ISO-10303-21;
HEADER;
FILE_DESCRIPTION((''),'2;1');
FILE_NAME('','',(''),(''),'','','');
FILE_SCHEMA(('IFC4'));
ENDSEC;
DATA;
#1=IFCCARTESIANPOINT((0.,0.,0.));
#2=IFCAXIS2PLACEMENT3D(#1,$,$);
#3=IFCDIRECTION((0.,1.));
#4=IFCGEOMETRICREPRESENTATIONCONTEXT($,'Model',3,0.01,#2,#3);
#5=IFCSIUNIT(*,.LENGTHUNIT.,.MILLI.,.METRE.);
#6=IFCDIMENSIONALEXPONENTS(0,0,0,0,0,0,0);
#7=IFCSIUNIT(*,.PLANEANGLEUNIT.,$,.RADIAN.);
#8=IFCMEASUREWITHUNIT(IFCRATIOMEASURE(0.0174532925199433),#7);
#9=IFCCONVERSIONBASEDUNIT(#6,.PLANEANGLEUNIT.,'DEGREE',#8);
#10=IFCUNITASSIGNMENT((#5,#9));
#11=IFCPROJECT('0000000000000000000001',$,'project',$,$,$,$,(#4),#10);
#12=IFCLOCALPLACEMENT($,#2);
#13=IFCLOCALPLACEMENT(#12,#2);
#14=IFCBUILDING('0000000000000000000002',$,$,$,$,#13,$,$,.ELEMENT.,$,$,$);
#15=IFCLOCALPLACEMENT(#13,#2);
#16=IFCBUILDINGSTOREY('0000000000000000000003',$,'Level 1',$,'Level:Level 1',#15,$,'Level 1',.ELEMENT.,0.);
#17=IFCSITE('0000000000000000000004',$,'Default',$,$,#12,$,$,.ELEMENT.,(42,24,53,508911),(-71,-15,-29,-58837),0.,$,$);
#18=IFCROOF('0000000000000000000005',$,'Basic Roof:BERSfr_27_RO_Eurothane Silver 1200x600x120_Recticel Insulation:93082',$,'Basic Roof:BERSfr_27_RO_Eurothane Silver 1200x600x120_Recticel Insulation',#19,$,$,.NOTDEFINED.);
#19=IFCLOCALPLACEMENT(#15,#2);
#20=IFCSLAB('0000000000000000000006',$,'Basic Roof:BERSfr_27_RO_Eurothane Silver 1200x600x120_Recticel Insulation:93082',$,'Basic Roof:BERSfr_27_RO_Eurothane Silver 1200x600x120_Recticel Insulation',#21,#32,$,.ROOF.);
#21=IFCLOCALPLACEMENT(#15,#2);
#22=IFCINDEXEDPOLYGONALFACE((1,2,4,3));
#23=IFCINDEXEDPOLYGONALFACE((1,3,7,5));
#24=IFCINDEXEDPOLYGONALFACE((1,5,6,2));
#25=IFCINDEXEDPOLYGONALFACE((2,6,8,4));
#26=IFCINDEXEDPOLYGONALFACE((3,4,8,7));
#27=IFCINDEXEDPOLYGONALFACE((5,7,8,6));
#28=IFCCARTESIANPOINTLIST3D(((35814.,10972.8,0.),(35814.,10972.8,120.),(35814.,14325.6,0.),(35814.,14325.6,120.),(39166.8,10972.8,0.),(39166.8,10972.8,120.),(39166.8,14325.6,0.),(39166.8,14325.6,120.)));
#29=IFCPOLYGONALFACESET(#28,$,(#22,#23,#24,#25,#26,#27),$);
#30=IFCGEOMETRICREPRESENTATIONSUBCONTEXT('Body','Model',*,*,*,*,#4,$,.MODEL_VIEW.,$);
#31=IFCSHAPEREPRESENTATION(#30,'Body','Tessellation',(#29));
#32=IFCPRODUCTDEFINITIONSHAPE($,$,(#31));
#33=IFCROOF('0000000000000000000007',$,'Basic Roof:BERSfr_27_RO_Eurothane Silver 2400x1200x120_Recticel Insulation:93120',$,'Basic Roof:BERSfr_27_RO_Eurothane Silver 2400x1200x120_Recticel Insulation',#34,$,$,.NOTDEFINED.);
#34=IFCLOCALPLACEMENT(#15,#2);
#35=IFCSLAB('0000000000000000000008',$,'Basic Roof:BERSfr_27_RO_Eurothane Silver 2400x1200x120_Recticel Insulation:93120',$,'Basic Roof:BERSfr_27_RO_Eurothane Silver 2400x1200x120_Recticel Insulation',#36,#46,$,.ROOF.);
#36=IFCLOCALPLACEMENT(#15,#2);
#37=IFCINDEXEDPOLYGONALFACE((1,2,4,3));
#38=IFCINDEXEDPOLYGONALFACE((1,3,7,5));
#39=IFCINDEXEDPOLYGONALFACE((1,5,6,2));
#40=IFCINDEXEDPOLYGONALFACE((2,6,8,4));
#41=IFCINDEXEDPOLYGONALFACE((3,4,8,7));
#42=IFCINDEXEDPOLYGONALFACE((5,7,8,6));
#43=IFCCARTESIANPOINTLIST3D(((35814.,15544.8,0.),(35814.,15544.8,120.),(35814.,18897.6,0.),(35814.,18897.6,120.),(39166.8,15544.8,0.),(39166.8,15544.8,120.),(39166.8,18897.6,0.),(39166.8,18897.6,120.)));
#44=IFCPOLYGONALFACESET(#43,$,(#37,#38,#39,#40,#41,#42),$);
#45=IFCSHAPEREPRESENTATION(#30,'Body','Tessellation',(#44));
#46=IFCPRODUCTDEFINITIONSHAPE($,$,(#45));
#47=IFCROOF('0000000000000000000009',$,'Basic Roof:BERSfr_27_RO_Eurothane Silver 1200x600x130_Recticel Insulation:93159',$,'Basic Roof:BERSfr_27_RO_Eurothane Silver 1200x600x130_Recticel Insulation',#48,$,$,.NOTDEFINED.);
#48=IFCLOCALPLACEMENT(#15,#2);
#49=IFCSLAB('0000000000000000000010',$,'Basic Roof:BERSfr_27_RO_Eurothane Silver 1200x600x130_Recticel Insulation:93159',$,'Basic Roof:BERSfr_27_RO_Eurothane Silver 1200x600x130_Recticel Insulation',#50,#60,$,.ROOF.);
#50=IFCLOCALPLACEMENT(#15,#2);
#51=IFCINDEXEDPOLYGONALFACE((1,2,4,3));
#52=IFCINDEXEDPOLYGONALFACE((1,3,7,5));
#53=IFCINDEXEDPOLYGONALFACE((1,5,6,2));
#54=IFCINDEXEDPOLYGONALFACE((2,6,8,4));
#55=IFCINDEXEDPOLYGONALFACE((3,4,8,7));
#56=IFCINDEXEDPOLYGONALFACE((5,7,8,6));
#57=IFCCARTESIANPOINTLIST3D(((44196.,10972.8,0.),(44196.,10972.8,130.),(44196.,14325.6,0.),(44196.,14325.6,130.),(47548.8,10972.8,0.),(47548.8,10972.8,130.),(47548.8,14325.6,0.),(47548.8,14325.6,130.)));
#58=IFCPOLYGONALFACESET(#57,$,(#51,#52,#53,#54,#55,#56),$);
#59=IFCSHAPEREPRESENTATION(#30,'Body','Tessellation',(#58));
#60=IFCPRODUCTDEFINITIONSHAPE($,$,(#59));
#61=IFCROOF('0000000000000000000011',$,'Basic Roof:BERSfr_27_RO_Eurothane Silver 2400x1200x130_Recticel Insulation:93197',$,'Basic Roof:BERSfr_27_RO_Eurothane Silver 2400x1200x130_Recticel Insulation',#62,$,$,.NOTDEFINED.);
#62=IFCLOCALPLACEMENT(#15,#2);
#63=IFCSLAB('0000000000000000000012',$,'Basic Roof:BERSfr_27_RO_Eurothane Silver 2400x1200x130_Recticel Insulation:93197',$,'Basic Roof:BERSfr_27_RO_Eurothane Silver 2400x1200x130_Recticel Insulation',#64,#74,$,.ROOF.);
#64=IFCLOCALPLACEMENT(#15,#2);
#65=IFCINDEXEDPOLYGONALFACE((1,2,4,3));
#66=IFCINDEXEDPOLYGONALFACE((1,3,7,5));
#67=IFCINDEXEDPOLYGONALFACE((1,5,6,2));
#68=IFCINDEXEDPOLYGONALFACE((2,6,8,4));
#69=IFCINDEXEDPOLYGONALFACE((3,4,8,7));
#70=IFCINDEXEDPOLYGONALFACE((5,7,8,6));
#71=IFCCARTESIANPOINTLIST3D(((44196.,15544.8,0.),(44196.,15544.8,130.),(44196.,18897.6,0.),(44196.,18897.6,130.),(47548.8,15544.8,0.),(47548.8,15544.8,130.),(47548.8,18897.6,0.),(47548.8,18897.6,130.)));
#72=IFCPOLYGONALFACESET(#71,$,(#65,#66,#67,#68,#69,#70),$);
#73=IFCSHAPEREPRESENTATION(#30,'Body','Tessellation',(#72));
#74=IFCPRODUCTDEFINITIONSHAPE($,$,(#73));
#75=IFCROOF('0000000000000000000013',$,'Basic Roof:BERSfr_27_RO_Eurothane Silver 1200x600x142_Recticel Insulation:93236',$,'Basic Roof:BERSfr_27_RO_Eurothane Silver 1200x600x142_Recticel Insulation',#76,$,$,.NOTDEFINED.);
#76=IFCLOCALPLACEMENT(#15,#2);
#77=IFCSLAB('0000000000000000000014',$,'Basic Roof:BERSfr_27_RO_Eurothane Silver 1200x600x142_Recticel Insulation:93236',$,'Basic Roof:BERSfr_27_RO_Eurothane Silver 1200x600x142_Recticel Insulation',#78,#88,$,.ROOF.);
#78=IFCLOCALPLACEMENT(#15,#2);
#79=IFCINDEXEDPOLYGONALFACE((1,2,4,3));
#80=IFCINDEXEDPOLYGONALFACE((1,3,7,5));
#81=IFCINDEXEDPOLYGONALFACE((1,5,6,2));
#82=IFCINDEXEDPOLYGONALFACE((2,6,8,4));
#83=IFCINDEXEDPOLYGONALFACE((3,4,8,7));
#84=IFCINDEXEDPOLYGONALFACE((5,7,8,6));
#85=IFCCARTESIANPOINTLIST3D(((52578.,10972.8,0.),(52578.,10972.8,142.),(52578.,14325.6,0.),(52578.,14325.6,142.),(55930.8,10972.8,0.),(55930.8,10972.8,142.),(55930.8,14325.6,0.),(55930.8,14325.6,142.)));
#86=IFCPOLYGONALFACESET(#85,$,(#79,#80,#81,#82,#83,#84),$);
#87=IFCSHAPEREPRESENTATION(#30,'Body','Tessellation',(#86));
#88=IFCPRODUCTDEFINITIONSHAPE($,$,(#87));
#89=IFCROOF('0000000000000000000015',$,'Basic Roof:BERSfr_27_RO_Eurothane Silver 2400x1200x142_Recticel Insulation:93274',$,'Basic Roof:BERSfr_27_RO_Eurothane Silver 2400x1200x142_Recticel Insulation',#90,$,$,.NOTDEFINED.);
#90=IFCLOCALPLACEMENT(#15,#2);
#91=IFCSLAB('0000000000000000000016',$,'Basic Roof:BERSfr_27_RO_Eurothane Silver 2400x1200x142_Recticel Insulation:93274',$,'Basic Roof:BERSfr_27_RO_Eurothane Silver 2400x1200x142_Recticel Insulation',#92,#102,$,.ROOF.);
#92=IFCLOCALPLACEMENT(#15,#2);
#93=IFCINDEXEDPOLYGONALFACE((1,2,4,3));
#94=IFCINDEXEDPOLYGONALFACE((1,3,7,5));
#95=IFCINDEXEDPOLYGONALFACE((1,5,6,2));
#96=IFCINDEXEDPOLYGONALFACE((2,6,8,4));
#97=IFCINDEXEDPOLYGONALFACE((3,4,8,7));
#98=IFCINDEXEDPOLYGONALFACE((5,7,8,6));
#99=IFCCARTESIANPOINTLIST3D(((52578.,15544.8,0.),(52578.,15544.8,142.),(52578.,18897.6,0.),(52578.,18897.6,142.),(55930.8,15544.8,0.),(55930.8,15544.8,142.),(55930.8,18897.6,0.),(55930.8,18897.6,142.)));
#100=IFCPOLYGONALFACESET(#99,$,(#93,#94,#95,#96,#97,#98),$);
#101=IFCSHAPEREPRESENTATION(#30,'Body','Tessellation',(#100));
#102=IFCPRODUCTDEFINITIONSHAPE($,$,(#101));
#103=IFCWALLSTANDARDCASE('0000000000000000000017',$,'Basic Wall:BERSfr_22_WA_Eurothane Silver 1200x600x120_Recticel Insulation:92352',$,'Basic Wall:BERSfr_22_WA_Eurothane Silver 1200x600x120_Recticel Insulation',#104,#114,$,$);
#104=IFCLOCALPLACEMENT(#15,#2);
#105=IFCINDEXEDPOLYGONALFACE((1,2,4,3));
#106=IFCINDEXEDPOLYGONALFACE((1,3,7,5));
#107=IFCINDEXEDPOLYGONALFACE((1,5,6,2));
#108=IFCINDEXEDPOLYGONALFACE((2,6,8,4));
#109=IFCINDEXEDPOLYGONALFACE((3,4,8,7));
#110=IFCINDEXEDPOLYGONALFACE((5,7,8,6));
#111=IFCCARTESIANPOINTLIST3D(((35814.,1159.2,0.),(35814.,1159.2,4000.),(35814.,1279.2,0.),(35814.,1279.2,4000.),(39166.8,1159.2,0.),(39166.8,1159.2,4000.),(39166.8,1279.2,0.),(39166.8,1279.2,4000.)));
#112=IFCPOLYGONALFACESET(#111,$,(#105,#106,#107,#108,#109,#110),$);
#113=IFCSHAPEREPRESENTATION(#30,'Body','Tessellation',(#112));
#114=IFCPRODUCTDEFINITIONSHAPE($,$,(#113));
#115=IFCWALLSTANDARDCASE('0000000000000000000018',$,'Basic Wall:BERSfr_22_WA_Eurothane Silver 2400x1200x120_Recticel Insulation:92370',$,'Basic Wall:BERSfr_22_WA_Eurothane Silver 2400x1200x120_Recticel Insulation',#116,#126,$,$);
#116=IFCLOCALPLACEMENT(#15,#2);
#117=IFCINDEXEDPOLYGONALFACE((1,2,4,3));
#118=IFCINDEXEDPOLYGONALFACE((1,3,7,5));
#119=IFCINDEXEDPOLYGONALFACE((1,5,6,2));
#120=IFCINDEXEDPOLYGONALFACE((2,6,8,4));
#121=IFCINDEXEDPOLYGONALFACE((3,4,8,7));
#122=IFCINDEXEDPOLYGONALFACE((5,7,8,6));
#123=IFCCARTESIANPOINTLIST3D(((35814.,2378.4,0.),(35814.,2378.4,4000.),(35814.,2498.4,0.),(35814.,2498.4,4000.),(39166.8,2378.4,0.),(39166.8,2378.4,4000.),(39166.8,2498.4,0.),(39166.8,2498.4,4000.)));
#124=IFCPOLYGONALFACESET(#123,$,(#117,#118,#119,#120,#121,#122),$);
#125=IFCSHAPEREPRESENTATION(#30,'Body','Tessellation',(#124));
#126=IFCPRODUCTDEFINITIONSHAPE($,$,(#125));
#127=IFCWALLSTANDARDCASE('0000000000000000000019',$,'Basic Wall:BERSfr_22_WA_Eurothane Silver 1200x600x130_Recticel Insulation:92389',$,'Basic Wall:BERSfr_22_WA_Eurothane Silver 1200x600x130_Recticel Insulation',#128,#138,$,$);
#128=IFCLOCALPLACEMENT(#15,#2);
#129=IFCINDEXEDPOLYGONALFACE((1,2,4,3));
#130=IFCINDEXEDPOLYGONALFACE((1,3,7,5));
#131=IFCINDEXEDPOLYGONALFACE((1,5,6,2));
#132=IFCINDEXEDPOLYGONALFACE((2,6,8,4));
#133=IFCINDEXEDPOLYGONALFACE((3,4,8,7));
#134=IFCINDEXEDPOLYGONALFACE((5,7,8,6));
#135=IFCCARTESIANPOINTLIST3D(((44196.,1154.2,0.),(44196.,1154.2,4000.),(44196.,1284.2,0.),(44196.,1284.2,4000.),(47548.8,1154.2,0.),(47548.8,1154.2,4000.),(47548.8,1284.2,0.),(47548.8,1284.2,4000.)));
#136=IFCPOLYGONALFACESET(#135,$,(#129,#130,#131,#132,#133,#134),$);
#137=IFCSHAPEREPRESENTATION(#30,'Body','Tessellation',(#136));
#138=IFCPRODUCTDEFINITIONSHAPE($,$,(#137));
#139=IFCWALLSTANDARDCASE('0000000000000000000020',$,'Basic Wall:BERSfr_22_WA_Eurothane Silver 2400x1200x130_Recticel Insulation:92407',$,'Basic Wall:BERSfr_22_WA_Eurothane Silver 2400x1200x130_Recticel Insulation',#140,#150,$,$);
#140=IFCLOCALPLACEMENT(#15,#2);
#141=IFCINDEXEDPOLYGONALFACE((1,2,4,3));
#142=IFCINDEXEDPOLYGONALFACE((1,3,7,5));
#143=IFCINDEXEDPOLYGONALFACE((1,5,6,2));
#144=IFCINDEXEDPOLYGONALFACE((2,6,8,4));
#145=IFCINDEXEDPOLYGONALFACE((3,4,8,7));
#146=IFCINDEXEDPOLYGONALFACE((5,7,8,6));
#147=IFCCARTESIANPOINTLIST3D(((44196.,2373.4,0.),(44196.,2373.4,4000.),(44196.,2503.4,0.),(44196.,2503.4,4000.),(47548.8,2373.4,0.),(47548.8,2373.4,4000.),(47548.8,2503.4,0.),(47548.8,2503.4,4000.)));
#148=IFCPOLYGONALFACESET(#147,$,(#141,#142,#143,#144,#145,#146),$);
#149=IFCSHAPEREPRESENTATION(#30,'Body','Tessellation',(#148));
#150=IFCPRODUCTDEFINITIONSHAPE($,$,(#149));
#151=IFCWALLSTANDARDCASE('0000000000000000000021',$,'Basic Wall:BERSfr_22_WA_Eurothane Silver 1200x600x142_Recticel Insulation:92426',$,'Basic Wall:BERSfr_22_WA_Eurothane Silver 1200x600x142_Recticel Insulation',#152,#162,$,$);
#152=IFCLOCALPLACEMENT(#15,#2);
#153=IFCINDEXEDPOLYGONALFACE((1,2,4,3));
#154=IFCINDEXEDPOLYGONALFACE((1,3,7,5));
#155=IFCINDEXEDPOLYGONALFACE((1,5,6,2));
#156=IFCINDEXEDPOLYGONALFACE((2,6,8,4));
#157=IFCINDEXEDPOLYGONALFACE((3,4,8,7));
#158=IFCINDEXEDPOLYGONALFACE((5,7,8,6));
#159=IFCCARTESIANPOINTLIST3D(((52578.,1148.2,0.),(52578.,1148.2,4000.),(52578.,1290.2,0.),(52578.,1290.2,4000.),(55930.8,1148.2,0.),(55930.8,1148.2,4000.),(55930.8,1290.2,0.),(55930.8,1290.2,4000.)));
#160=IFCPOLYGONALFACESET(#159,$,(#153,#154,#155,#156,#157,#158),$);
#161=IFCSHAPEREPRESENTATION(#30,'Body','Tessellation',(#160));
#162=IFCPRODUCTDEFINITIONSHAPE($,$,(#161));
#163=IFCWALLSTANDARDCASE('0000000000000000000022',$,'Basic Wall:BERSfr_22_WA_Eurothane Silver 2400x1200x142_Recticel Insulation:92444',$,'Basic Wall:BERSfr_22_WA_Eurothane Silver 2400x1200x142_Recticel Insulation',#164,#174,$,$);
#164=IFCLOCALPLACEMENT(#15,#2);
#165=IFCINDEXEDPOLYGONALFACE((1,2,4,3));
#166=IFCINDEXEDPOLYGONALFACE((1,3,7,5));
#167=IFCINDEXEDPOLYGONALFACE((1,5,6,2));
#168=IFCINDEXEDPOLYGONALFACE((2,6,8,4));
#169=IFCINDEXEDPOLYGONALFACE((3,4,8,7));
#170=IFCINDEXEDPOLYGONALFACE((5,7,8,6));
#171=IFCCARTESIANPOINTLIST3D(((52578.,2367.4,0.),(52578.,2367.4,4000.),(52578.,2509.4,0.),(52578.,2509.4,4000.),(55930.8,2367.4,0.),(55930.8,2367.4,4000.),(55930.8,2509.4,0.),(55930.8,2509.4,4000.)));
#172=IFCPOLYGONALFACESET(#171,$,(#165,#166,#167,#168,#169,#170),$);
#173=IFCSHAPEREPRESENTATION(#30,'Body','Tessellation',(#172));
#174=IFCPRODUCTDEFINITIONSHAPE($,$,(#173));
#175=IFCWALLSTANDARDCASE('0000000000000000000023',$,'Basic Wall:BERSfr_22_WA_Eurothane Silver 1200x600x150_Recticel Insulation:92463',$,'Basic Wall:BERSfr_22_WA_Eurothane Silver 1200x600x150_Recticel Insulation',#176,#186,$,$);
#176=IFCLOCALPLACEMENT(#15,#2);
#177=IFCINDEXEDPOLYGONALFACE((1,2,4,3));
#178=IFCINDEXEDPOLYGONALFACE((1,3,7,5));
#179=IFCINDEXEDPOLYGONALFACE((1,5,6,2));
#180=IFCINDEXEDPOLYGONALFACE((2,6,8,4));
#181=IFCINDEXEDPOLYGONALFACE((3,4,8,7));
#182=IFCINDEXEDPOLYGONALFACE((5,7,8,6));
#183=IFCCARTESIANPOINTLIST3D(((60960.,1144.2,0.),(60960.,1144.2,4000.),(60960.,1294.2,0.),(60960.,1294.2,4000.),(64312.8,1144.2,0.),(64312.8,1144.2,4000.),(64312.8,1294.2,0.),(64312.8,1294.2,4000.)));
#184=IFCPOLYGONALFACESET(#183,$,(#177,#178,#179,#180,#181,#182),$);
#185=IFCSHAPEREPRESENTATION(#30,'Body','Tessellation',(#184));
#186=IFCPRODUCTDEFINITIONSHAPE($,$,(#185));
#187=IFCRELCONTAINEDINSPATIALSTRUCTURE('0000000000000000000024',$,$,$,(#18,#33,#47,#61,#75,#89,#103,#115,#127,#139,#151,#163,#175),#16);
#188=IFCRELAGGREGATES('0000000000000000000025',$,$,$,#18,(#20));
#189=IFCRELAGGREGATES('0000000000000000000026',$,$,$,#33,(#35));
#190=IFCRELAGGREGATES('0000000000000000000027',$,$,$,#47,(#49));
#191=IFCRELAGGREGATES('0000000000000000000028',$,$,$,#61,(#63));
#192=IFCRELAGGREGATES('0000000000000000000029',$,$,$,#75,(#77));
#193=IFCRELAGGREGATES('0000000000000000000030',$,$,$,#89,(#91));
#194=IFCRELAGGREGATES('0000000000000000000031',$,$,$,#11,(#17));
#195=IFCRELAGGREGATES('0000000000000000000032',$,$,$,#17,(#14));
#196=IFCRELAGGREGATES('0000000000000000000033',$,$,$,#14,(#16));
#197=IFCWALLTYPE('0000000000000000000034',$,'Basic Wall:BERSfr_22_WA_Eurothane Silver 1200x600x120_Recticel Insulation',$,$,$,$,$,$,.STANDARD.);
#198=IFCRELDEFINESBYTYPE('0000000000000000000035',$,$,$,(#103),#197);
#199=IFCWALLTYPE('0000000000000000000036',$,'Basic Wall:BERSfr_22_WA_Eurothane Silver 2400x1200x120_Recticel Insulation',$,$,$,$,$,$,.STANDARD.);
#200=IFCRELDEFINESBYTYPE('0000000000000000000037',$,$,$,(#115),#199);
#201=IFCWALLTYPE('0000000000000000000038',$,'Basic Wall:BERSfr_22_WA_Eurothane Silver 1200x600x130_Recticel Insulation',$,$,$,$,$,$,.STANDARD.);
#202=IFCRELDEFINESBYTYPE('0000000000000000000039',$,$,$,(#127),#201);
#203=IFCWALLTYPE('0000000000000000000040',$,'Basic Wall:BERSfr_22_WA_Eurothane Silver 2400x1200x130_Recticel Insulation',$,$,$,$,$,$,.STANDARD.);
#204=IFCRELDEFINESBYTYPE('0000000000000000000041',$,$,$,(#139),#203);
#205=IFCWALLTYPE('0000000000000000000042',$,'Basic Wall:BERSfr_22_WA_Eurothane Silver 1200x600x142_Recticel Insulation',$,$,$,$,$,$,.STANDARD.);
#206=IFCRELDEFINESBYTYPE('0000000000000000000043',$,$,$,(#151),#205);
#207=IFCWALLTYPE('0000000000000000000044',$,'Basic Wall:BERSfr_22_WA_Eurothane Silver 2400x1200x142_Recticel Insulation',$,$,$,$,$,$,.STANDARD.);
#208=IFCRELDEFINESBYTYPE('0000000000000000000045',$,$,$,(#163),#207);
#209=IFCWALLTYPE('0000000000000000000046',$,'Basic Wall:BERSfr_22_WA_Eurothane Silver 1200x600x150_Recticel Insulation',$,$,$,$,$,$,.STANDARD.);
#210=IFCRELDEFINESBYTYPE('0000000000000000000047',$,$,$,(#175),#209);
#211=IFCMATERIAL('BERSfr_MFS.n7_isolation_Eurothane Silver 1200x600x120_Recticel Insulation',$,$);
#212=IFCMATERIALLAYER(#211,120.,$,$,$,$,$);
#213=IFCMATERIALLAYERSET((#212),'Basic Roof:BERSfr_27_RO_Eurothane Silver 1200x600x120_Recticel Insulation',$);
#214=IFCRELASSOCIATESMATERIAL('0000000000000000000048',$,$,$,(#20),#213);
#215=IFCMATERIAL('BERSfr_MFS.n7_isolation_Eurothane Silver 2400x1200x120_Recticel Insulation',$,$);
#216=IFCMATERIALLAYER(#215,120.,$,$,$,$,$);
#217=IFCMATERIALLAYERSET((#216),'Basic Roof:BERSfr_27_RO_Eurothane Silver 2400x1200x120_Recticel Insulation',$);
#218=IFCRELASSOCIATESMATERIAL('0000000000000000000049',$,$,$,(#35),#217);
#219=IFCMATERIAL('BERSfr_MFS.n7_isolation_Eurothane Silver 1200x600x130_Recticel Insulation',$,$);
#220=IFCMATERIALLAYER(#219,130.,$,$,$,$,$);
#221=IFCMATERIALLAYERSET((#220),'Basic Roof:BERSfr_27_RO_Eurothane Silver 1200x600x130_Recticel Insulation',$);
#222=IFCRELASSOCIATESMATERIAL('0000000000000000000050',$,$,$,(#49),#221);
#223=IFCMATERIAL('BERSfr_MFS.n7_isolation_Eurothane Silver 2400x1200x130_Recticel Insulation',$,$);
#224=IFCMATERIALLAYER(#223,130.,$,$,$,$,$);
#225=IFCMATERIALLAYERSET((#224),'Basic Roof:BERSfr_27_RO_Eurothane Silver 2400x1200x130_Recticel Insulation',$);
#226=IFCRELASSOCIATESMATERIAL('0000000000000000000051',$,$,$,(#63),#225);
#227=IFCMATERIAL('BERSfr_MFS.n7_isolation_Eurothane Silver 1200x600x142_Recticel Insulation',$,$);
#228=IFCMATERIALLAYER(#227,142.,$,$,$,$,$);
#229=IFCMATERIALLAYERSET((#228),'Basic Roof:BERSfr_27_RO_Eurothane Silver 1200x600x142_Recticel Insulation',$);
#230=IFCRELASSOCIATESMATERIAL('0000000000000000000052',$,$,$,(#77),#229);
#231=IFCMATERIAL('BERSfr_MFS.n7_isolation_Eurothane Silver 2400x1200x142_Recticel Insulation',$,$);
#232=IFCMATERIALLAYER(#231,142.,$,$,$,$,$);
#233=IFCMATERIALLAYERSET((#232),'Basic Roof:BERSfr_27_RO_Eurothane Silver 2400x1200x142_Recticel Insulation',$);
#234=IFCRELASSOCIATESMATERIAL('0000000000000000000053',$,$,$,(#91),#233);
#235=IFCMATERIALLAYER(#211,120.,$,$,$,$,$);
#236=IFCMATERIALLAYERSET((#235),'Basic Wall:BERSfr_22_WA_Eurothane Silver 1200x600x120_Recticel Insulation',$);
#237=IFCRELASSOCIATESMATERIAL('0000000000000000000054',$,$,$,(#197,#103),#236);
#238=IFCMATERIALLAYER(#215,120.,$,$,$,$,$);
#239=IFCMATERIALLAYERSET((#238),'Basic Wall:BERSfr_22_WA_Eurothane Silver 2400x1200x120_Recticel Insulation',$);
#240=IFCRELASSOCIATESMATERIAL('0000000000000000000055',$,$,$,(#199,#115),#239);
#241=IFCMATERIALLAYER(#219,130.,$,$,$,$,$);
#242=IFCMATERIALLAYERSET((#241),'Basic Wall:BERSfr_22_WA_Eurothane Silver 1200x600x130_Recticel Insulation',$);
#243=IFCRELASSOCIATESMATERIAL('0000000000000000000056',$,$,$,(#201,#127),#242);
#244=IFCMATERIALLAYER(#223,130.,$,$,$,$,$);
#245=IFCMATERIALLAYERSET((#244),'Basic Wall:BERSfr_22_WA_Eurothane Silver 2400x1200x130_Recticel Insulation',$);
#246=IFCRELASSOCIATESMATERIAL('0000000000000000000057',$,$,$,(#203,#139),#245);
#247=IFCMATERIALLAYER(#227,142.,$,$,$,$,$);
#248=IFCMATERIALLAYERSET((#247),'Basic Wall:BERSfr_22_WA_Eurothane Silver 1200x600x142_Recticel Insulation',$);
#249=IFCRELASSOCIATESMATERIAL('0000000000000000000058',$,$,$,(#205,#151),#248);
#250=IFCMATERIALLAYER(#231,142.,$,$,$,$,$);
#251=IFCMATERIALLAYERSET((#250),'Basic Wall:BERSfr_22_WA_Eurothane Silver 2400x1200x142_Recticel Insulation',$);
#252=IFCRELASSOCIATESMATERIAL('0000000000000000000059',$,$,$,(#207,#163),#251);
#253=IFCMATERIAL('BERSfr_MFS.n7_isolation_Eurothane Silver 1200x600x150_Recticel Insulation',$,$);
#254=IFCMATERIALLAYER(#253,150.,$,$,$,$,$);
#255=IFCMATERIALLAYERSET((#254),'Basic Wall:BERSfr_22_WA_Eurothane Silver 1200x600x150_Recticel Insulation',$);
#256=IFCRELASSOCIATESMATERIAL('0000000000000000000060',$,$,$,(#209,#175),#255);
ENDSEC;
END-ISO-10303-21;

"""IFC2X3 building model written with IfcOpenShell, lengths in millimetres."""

from ifc_helpers import new_model, entity, si_unit, converted_unit, direction, frame, frame_2d, origin, place, context, subcontext, project, spatial, rectangle, extrude, material, layer, layer_set, layer_usage, type_object, element, aggregate, save


model = new_model("IFC2X3")

# Units and contexts
model_context = context("Model", 3, precision=0.01, world=origin(), true_north=direction((0.0, 1.0)))
body_context = subcontext(model_context, "Body", "Model", "MODEL_VIEW")
ifc_project = project(units=[si_unit("LENGTHUNIT", "METRE", prefix="MILLI"), converted_unit("PLANEANGLEUNIT", "DEGREE", entity("IfcRatioMeasure", 0.0174532925199433), si_unit("PLANEANGLEUNIT", "RADIAN"), dimensions=[0, 0, 0, 0, 0, 0, 0])], contexts=[model_context])

# Site, building, storey
site_placement = place(None, origin())
site = spatial("IfcSite", under=ifc_project, at=site_placement, Name="Default", CompositionType="ELEMENT", RefLatitude=(42, 24, 53, 508911), RefLongitude=(-71, -15, -29, -58837), RefElevation=0.0)
building_placement = place(site_placement, origin())
building = spatial("IfcBuilding", under=site, at=building_placement, CompositionType="ELEMENT")
storey_placement = place(building_placement, origin())
storey = spatial("IfcBuildingStorey", under=building, at=storey_placement, Name="Level 1", ObjectType="Level:Level 1", LongName="Level 1", CompositionType="ELEMENT", Elevation=0.0)

# Roofs, slabs
roof_1_placement = place(storey_placement, frame((35814.0, 10972.8, 0.0)))
roof_1 = element("IfcRoof", 1, at=roof_1_placement, inside=storey, Name="Basic Roof:BERSfr_27_RO_Eurothane Silver 1200x600x120_Recticel Insulation:93082", ObjectType="Basic Roof:BERSfr_27_RO_Eurothane Silver 1200x600x120_Recticel Insulation", ShapeType="NOTDEFINED")
ifc_material_1 = material(Name="BERSfr_MFS.n7_isolation_Eurothane Silver 1200x600x120_Recticel Insulation")
ifc_layer_1 = layer(ifc_material_1, 120.0)
ifc_layer_set_1 = layer_set([ifc_layer_1], Name="Basic Roof:BERSfr_27_RO_Eurothane Silver 1200x600x120_Recticel Insulation")
slab_1_placement = place(roof_1_placement, origin())
slab_1 = element("IfcSlab", 2, at=slab_1_placement, material=ifc_layer_set_1, Name="Basic Roof:BERSfr_27_RO_Eurothane Silver 1200x600x120_Recticel Insulation:93082", ObjectType="Basic Roof:BERSfr_27_RO_Eurothane Silver 1200x600x120_Recticel Insulation", PredefinedType="ROOF", context=body_context, shape_type="SweptSolid", body=[
    extrude(rectangle(XDim=3352.8, YDim=3352.8, at=frame_2d((0.0, 0.0), x_axis=(-1.0, 0.0))), frame((1676.4, 1676.4, 0.0)), (0.0, 0.0, 1.0), 120.0),
])
aggregate(roof_1, [slab_1])
roof_2_placement = place(storey_placement, frame((35814.0, 15544.8, 0.0)))
roof_2 = element("IfcRoof", 3, at=roof_2_placement, inside=storey, Name="Basic Roof:BERSfr_27_RO_Eurothane Silver 2400x1200x120_Recticel Insulation:93120", ObjectType="Basic Roof:BERSfr_27_RO_Eurothane Silver 2400x1200x120_Recticel Insulation", ShapeType="NOTDEFINED")
ifc_material_2 = material(Name="BERSfr_MFS.n7_isolation_Eurothane Silver 2400x1200x120_Recticel Insulation")
ifc_layer_2 = layer(ifc_material_2, 120.0)
ifc_layer_set_2 = layer_set([ifc_layer_2], Name="Basic Roof:BERSfr_27_RO_Eurothane Silver 2400x1200x120_Recticel Insulation")
slab_2_placement = place(roof_2_placement, origin())
slab_2 = element("IfcSlab", 4, at=slab_2_placement, material=ifc_layer_set_2, Name="Basic Roof:BERSfr_27_RO_Eurothane Silver 2400x1200x120_Recticel Insulation:93120", ObjectType="Basic Roof:BERSfr_27_RO_Eurothane Silver 2400x1200x120_Recticel Insulation", PredefinedType="ROOF", context=body_context, shape_type="SweptSolid", body=[
    extrude(rectangle(XDim=3352.8, YDim=3352.8, at=frame_2d((0.0, 0.0), x_axis=(-1.0, 0.0))), frame((1676.4, 1676.4, 0.0)), (0.0, 0.0, 1.0), 120.0),
])
aggregate(roof_2, [slab_2])
roof_3_placement = place(storey_placement, frame((44196.0, 10972.8, 0.0)))
roof_3 = element("IfcRoof", 5, at=roof_3_placement, inside=storey, Name="Basic Roof:BERSfr_27_RO_Eurothane Silver 1200x600x130_Recticel Insulation:93159", ObjectType="Basic Roof:BERSfr_27_RO_Eurothane Silver 1200x600x130_Recticel Insulation", ShapeType="NOTDEFINED")
ifc_material_3 = material(Name="BERSfr_MFS.n7_isolation_Eurothane Silver 1200x600x130_Recticel Insulation")
ifc_layer_3 = layer(ifc_material_3, 130.0)
ifc_layer_set_3 = layer_set([ifc_layer_3], Name="Basic Roof:BERSfr_27_RO_Eurothane Silver 1200x600x130_Recticel Insulation")
slab_3_placement = place(roof_3_placement, origin())
slab_3 = element("IfcSlab", 6, at=slab_3_placement, material=ifc_layer_set_3, Name="Basic Roof:BERSfr_27_RO_Eurothane Silver 1200x600x130_Recticel Insulation:93159", ObjectType="Basic Roof:BERSfr_27_RO_Eurothane Silver 1200x600x130_Recticel Insulation", PredefinedType="ROOF", context=body_context, shape_type="SweptSolid", body=[
    extrude(rectangle(XDim=3352.8, YDim=3352.8, at=frame_2d((0.0, 0.0), x_axis=(-1.0, 0.0))), frame((1676.4, 1676.4, 0.0)), (0.0, 0.0, 1.0), 130.0),
])
aggregate(roof_3, [slab_3])
roof_4_placement = place(storey_placement, frame((44196.0, 15544.8, 0.0)))
roof_4 = element("IfcRoof", 7, at=roof_4_placement, inside=storey, Name="Basic Roof:BERSfr_27_RO_Eurothane Silver 2400x1200x130_Recticel Insulation:93197", ObjectType="Basic Roof:BERSfr_27_RO_Eurothane Silver 2400x1200x130_Recticel Insulation", ShapeType="NOTDEFINED")
ifc_material_4 = material(Name="BERSfr_MFS.n7_isolation_Eurothane Silver 2400x1200x130_Recticel Insulation")
ifc_layer_4 = layer(ifc_material_4, 130.0)
ifc_layer_set_4 = layer_set([ifc_layer_4], Name="Basic Roof:BERSfr_27_RO_Eurothane Silver 2400x1200x130_Recticel Insulation")
slab_4_placement = place(roof_4_placement, origin())
slab_4 = element("IfcSlab", 8, at=slab_4_placement, material=ifc_layer_set_4, Name="Basic Roof:BERSfr_27_RO_Eurothane Silver 2400x1200x130_Recticel Insulation:93197", ObjectType="Basic Roof:BERSfr_27_RO_Eurothane Silver 2400x1200x130_Recticel Insulation", PredefinedType="ROOF", context=body_context, shape_type="SweptSolid", body=[
    extrude(rectangle(XDim=3352.8, YDim=3352.8, at=frame_2d((0.0, 0.0), x_axis=(-1.0, 0.0))), frame((1676.4, 1676.4, 0.0)), (0.0, 0.0, 1.0), 130.0),
])
aggregate(roof_4, [slab_4])
roof_5_placement = place(storey_placement, frame((52578.0, 10972.8, 0.0)))
roof_5 = element("IfcRoof", 9, at=roof_5_placement, inside=storey, Name="Basic Roof:BERSfr_27_RO_Eurothane Silver 1200x600x142_Recticel Insulation:93236", ObjectType="Basic Roof:BERSfr_27_RO_Eurothane Silver 1200x600x142_Recticel Insulation", ShapeType="NOTDEFINED")
ifc_material_5 = material(Name="BERSfr_MFS.n7_isolation_Eurothane Silver 1200x600x142_Recticel Insulation")
ifc_layer_5 = layer(ifc_material_5, 142.0)
ifc_layer_set_5 = layer_set([ifc_layer_5], Name="Basic Roof:BERSfr_27_RO_Eurothane Silver 1200x600x142_Recticel Insulation")
slab_5_placement = place(roof_5_placement, origin())
slab_5 = element("IfcSlab", 10, at=slab_5_placement, material=ifc_layer_set_5, Name="Basic Roof:BERSfr_27_RO_Eurothane Silver 1200x600x142_Recticel Insulation:93236", ObjectType="Basic Roof:BERSfr_27_RO_Eurothane Silver 1200x600x142_Recticel Insulation", PredefinedType="ROOF", context=body_context, shape_type="SweptSolid", body=[
    extrude(rectangle(XDim=3352.8, YDim=3352.8, at=frame_2d((0.0, 0.0), x_axis=(-1.0, 0.0))), frame((1676.4, 1676.4, 0.0)), (0.0, 0.0, 1.0), 142.0),
])
aggregate(roof_5, [slab_5])
roof_6_placement = place(storey_placement, frame((52578.0, 15544.8, 0.0)))
roof_6 = element("IfcRoof", 11, at=roof_6_placement, inside=storey, Name="Basic Roof:BERSfr_27_RO_Eurothane Silver 2400x1200x142_Recticel Insulation:93274", ObjectType="Basic Roof:BERSfr_27_RO_Eurothane Silver 2400x1200x142_Recticel Insulation", ShapeType="NOTDEFINED")
ifc_material_6 = material(Name="BERSfr_MFS.n7_isolation_Eurothane Silver 2400x1200x142_Recticel Insulation")
ifc_layer_6 = layer(ifc_material_6, 142.0)
ifc_layer_set_6 = layer_set([ifc_layer_6], Name="Basic Roof:BERSfr_27_RO_Eurothane Silver 2400x1200x142_Recticel Insulation")
slab_6_placement = place(roof_6_placement, origin())
slab_6 = element("IfcSlab", 12, at=slab_6_placement, material=ifc_layer_set_6, Name="Basic Roof:BERSfr_27_RO_Eurothane Silver 2400x1200x142_Recticel Insulation:93274", ObjectType="Basic Roof:BERSfr_27_RO_Eurothane Silver 2400x1200x142_Recticel Insulation", PredefinedType="ROOF", context=body_context, shape_type="SweptSolid", body=[
    extrude(rectangle(XDim=3352.8, YDim=3352.8, at=frame_2d((0.0, 0.0), x_axis=(-1.0, 0.0))), frame((1676.4, 1676.4, 0.0)), (0.0, 0.0, 1.0), 142.0),
])
aggregate(roof_6, [slab_6])

# Walls
ifc_layer_7 = layer(ifc_material_1, 120.0)
ifc_layer_set_7 = layer_set([ifc_layer_7], Name="Basic Wall:BERSfr_22_WA_Eurothane Silver 1200x600x120_Recticel Insulation")
ifc_layer_usage_1 = layer_usage(ifc_layer_set_7, "AXIS2", "NEGATIVE", 60.0)
wall_type_1 = type_object("IfcWallType", Name="Basic Wall:BERSfr_22_WA_Eurothane Silver 1200x600x120_Recticel Insulation", PredefinedType="STANDARD", material=ifc_layer_set_7)
wall_1_placement = place(storey_placement, frame((35814.0, 1219.2, 0.0)))
element("IfcWallStandardCase", 13, at=wall_1_placement, inside=storey, type_object=wall_type_1, material=ifc_layer_usage_1, Name="Basic Wall:BERSfr_22_WA_Eurothane Silver 1200x600x120_Recticel Insulation:92352", ObjectType="Basic Wall:BERSfr_22_WA_Eurothane Silver 1200x600x120_Recticel Insulation", context=body_context, shape_type="SweptSolid", body=[
    extrude(rectangle(XDim=3352.8, YDim=120.0, at=frame_2d((1676.4, 0.0), x_axis=(-1.0, 0.0))), origin(), (0.0, 0.0, 1.0), 4000.0),
])
ifc_layer_8 = layer(ifc_material_2, 120.0)
ifc_layer_set_8 = layer_set([ifc_layer_8], Name="Basic Wall:BERSfr_22_WA_Eurothane Silver 2400x1200x120_Recticel Insulation")
ifc_layer_usage_2 = layer_usage(ifc_layer_set_8, "AXIS2", "NEGATIVE", 60.0)
wall_type_2 = type_object("IfcWallType", Name="Basic Wall:BERSfr_22_WA_Eurothane Silver 2400x1200x120_Recticel Insulation", PredefinedType="STANDARD", material=ifc_layer_set_8)
wall_2_placement = place(storey_placement, frame((35814.0, 2438.4, 0.0)))
element("IfcWallStandardCase", 14, at=wall_2_placement, inside=storey, type_object=wall_type_2, material=ifc_layer_usage_2, Name="Basic Wall:BERSfr_22_WA_Eurothane Silver 2400x1200x120_Recticel Insulation:92370", ObjectType="Basic Wall:BERSfr_22_WA_Eurothane Silver 2400x1200x120_Recticel Insulation", context=body_context, shape_type="SweptSolid", body=[
    extrude(rectangle(XDim=3352.8, YDim=120.0, at=frame_2d((1676.4, 0.0), x_axis=(-1.0, 0.0))), origin(), (0.0, 0.0, 1.0), 4000.0),
])
ifc_layer_9 = layer(ifc_material_3, 130.0)
ifc_layer_set_9 = layer_set([ifc_layer_9], Name="Basic Wall:BERSfr_22_WA_Eurothane Silver 1200x600x130_Recticel Insulation")
ifc_layer_usage_3 = layer_usage(ifc_layer_set_9, "AXIS2", "NEGATIVE", 65.0)
wall_type_3 = type_object("IfcWallType", Name="Basic Wall:BERSfr_22_WA_Eurothane Silver 1200x600x130_Recticel Insulation", PredefinedType="STANDARD", material=ifc_layer_set_9)
wall_3_placement = place(storey_placement, frame((44196.0, 1219.2, 0.0)))
element("IfcWallStandardCase", 15, at=wall_3_placement, inside=storey, type_object=wall_type_3, material=ifc_layer_usage_3, Name="Basic Wall:BERSfr_22_WA_Eurothane Silver 1200x600x130_Recticel Insulation:92389", ObjectType="Basic Wall:BERSfr_22_WA_Eurothane Silver 1200x600x130_Recticel Insulation", context=body_context, shape_type="SweptSolid", body=[
    extrude(rectangle(XDim=3352.8, YDim=130.0, at=frame_2d((1676.4, 0.0), x_axis=(-1.0, 0.0))), origin(), (0.0, 0.0, 1.0), 4000.0),
])
ifc_layer_10 = layer(ifc_material_4, 130.0)
ifc_layer_set_10 = layer_set([ifc_layer_10], Name="Basic Wall:BERSfr_22_WA_Eurothane Silver 2400x1200x130_Recticel Insulation")
ifc_layer_usage_4 = layer_usage(ifc_layer_set_10, "AXIS2", "NEGATIVE", 65.0)
wall_type_4 = type_object("IfcWallType", Name="Basic Wall:BERSfr_22_WA_Eurothane Silver 2400x1200x130_Recticel Insulation", PredefinedType="STANDARD", material=ifc_layer_set_10)
wall_4_placement = place(storey_placement, frame((44196.0, 2438.4, 0.0)))
element("IfcWallStandardCase", 16, at=wall_4_placement, inside=storey, type_object=wall_type_4, material=ifc_layer_usage_4, Name="Basic Wall:BERSfr_22_WA_Eurothane Silver 2400x1200x130_Recticel Insulation:92407", ObjectType="Basic Wall:BERSfr_22_WA_Eurothane Silver 2400x1200x130_Recticel Insulation", context=body_context, shape_type="SweptSolid", body=[
    extrude(rectangle(XDim=3352.8, YDim=130.0, at=frame_2d((1676.4, 0.0), x_axis=(-1.0, 0.0))), origin(), (0.0, 0.0, 1.0), 4000.0),
])
ifc_layer_11 = layer(ifc_material_5, 142.0)
ifc_layer_set_11 = layer_set([ifc_layer_11], Name="Basic Wall:BERSfr_22_WA_Eurothane Silver 1200x600x142_Recticel Insulation")
ifc_layer_usage_5 = layer_usage(ifc_layer_set_11, "AXIS2", "NEGATIVE", 71.0)
wall_type_5 = type_object("IfcWallType", Name="Basic Wall:BERSfr_22_WA_Eurothane Silver 1200x600x142_Recticel Insulation", PredefinedType="STANDARD", material=ifc_layer_set_11)
wall_5_placement = place(storey_placement, frame((52578.0, 1219.2, 0.0)))
element("IfcWallStandardCase", 17, at=wall_5_placement, inside=storey, type_object=wall_type_5, material=ifc_layer_usage_5, Name="Basic Wall:BERSfr_22_WA_Eurothane Silver 1200x600x142_Recticel Insulation:92426", ObjectType="Basic Wall:BERSfr_22_WA_Eurothane Silver 1200x600x142_Recticel Insulation", context=body_context, shape_type="SweptSolid", body=[
    extrude(rectangle(XDim=3352.8, YDim=142.0, at=frame_2d((1676.4, 0.0), x_axis=(-1.0, 0.0))), origin(), (0.0, 0.0, 1.0), 4000.0),
])
ifc_layer_12 = layer(ifc_material_6, 142.0)
ifc_layer_set_12 = layer_set([ifc_layer_12], Name="Basic Wall:BERSfr_22_WA_Eurothane Silver 2400x1200x142_Recticel Insulation")
ifc_layer_usage_6 = layer_usage(ifc_layer_set_12, "AXIS2", "NEGATIVE", 71.0)
wall_type_6 = type_object("IfcWallType", Name="Basic Wall:BERSfr_22_WA_Eurothane Silver 2400x1200x142_Recticel Insulation", PredefinedType="STANDARD", material=ifc_layer_set_12)
wall_6_placement = place(storey_placement, frame((52578.0, 2438.4, 0.0)))
element("IfcWallStandardCase", 18, at=wall_6_placement, inside=storey, type_object=wall_type_6, material=ifc_layer_usage_6, Name="Basic Wall:BERSfr_22_WA_Eurothane Silver 2400x1200x142_Recticel Insulation:92444", ObjectType="Basic Wall:BERSfr_22_WA_Eurothane Silver 2400x1200x142_Recticel Insulation", context=body_context, shape_type="SweptSolid", body=[
    extrude(rectangle(XDim=3352.8, YDim=142.0, at=frame_2d((1676.4, 0.0), x_axis=(-1.0, 0.0))), origin(), (0.0, 0.0, 1.0), 4000.0),
])
ifc_material_7 = material(Name="BERSfr_MFS.n7_isolation_Eurothane Silver 1200x600x150_Recticel Insulation")
ifc_layer_13 = layer(ifc_material_7, 150.0)
ifc_layer_set_13 = layer_set([ifc_layer_13], Name="Basic Wall:BERSfr_22_WA_Eurothane Silver 1200x600x150_Recticel Insulation")
ifc_layer_usage_7 = layer_usage(ifc_layer_set_13, "AXIS2", "NEGATIVE", 75.0)
wall_type_7 = type_object("IfcWallType", Name="Basic Wall:BERSfr_22_WA_Eurothane Silver 1200x600x150_Recticel Insulation", PredefinedType="STANDARD", material=ifc_layer_set_13)
wall_7_placement = place(storey_placement, frame((60960.0, 1219.2, 0.0)))
element("IfcWallStandardCase", 19, at=wall_7_placement, inside=storey, type_object=wall_type_7, material=ifc_layer_usage_7, Name="Basic Wall:BERSfr_22_WA_Eurothane Silver 1200x600x150_Recticel Insulation:92463", ObjectType="Basic Wall:BERSfr_22_WA_Eurothane Silver 1200x600x150_Recticel Insulation", context=body_context, shape_type="SweptSolid", body=[
    extrude(rectangle(XDim=3352.8, YDim=150.0, at=frame_2d((1676.4, 0.0), x_axis=(-1.0, 0.0))), origin(), (0.0, 0.0, 1.0), 4000.0),
])

save(model, "model.ifc")
